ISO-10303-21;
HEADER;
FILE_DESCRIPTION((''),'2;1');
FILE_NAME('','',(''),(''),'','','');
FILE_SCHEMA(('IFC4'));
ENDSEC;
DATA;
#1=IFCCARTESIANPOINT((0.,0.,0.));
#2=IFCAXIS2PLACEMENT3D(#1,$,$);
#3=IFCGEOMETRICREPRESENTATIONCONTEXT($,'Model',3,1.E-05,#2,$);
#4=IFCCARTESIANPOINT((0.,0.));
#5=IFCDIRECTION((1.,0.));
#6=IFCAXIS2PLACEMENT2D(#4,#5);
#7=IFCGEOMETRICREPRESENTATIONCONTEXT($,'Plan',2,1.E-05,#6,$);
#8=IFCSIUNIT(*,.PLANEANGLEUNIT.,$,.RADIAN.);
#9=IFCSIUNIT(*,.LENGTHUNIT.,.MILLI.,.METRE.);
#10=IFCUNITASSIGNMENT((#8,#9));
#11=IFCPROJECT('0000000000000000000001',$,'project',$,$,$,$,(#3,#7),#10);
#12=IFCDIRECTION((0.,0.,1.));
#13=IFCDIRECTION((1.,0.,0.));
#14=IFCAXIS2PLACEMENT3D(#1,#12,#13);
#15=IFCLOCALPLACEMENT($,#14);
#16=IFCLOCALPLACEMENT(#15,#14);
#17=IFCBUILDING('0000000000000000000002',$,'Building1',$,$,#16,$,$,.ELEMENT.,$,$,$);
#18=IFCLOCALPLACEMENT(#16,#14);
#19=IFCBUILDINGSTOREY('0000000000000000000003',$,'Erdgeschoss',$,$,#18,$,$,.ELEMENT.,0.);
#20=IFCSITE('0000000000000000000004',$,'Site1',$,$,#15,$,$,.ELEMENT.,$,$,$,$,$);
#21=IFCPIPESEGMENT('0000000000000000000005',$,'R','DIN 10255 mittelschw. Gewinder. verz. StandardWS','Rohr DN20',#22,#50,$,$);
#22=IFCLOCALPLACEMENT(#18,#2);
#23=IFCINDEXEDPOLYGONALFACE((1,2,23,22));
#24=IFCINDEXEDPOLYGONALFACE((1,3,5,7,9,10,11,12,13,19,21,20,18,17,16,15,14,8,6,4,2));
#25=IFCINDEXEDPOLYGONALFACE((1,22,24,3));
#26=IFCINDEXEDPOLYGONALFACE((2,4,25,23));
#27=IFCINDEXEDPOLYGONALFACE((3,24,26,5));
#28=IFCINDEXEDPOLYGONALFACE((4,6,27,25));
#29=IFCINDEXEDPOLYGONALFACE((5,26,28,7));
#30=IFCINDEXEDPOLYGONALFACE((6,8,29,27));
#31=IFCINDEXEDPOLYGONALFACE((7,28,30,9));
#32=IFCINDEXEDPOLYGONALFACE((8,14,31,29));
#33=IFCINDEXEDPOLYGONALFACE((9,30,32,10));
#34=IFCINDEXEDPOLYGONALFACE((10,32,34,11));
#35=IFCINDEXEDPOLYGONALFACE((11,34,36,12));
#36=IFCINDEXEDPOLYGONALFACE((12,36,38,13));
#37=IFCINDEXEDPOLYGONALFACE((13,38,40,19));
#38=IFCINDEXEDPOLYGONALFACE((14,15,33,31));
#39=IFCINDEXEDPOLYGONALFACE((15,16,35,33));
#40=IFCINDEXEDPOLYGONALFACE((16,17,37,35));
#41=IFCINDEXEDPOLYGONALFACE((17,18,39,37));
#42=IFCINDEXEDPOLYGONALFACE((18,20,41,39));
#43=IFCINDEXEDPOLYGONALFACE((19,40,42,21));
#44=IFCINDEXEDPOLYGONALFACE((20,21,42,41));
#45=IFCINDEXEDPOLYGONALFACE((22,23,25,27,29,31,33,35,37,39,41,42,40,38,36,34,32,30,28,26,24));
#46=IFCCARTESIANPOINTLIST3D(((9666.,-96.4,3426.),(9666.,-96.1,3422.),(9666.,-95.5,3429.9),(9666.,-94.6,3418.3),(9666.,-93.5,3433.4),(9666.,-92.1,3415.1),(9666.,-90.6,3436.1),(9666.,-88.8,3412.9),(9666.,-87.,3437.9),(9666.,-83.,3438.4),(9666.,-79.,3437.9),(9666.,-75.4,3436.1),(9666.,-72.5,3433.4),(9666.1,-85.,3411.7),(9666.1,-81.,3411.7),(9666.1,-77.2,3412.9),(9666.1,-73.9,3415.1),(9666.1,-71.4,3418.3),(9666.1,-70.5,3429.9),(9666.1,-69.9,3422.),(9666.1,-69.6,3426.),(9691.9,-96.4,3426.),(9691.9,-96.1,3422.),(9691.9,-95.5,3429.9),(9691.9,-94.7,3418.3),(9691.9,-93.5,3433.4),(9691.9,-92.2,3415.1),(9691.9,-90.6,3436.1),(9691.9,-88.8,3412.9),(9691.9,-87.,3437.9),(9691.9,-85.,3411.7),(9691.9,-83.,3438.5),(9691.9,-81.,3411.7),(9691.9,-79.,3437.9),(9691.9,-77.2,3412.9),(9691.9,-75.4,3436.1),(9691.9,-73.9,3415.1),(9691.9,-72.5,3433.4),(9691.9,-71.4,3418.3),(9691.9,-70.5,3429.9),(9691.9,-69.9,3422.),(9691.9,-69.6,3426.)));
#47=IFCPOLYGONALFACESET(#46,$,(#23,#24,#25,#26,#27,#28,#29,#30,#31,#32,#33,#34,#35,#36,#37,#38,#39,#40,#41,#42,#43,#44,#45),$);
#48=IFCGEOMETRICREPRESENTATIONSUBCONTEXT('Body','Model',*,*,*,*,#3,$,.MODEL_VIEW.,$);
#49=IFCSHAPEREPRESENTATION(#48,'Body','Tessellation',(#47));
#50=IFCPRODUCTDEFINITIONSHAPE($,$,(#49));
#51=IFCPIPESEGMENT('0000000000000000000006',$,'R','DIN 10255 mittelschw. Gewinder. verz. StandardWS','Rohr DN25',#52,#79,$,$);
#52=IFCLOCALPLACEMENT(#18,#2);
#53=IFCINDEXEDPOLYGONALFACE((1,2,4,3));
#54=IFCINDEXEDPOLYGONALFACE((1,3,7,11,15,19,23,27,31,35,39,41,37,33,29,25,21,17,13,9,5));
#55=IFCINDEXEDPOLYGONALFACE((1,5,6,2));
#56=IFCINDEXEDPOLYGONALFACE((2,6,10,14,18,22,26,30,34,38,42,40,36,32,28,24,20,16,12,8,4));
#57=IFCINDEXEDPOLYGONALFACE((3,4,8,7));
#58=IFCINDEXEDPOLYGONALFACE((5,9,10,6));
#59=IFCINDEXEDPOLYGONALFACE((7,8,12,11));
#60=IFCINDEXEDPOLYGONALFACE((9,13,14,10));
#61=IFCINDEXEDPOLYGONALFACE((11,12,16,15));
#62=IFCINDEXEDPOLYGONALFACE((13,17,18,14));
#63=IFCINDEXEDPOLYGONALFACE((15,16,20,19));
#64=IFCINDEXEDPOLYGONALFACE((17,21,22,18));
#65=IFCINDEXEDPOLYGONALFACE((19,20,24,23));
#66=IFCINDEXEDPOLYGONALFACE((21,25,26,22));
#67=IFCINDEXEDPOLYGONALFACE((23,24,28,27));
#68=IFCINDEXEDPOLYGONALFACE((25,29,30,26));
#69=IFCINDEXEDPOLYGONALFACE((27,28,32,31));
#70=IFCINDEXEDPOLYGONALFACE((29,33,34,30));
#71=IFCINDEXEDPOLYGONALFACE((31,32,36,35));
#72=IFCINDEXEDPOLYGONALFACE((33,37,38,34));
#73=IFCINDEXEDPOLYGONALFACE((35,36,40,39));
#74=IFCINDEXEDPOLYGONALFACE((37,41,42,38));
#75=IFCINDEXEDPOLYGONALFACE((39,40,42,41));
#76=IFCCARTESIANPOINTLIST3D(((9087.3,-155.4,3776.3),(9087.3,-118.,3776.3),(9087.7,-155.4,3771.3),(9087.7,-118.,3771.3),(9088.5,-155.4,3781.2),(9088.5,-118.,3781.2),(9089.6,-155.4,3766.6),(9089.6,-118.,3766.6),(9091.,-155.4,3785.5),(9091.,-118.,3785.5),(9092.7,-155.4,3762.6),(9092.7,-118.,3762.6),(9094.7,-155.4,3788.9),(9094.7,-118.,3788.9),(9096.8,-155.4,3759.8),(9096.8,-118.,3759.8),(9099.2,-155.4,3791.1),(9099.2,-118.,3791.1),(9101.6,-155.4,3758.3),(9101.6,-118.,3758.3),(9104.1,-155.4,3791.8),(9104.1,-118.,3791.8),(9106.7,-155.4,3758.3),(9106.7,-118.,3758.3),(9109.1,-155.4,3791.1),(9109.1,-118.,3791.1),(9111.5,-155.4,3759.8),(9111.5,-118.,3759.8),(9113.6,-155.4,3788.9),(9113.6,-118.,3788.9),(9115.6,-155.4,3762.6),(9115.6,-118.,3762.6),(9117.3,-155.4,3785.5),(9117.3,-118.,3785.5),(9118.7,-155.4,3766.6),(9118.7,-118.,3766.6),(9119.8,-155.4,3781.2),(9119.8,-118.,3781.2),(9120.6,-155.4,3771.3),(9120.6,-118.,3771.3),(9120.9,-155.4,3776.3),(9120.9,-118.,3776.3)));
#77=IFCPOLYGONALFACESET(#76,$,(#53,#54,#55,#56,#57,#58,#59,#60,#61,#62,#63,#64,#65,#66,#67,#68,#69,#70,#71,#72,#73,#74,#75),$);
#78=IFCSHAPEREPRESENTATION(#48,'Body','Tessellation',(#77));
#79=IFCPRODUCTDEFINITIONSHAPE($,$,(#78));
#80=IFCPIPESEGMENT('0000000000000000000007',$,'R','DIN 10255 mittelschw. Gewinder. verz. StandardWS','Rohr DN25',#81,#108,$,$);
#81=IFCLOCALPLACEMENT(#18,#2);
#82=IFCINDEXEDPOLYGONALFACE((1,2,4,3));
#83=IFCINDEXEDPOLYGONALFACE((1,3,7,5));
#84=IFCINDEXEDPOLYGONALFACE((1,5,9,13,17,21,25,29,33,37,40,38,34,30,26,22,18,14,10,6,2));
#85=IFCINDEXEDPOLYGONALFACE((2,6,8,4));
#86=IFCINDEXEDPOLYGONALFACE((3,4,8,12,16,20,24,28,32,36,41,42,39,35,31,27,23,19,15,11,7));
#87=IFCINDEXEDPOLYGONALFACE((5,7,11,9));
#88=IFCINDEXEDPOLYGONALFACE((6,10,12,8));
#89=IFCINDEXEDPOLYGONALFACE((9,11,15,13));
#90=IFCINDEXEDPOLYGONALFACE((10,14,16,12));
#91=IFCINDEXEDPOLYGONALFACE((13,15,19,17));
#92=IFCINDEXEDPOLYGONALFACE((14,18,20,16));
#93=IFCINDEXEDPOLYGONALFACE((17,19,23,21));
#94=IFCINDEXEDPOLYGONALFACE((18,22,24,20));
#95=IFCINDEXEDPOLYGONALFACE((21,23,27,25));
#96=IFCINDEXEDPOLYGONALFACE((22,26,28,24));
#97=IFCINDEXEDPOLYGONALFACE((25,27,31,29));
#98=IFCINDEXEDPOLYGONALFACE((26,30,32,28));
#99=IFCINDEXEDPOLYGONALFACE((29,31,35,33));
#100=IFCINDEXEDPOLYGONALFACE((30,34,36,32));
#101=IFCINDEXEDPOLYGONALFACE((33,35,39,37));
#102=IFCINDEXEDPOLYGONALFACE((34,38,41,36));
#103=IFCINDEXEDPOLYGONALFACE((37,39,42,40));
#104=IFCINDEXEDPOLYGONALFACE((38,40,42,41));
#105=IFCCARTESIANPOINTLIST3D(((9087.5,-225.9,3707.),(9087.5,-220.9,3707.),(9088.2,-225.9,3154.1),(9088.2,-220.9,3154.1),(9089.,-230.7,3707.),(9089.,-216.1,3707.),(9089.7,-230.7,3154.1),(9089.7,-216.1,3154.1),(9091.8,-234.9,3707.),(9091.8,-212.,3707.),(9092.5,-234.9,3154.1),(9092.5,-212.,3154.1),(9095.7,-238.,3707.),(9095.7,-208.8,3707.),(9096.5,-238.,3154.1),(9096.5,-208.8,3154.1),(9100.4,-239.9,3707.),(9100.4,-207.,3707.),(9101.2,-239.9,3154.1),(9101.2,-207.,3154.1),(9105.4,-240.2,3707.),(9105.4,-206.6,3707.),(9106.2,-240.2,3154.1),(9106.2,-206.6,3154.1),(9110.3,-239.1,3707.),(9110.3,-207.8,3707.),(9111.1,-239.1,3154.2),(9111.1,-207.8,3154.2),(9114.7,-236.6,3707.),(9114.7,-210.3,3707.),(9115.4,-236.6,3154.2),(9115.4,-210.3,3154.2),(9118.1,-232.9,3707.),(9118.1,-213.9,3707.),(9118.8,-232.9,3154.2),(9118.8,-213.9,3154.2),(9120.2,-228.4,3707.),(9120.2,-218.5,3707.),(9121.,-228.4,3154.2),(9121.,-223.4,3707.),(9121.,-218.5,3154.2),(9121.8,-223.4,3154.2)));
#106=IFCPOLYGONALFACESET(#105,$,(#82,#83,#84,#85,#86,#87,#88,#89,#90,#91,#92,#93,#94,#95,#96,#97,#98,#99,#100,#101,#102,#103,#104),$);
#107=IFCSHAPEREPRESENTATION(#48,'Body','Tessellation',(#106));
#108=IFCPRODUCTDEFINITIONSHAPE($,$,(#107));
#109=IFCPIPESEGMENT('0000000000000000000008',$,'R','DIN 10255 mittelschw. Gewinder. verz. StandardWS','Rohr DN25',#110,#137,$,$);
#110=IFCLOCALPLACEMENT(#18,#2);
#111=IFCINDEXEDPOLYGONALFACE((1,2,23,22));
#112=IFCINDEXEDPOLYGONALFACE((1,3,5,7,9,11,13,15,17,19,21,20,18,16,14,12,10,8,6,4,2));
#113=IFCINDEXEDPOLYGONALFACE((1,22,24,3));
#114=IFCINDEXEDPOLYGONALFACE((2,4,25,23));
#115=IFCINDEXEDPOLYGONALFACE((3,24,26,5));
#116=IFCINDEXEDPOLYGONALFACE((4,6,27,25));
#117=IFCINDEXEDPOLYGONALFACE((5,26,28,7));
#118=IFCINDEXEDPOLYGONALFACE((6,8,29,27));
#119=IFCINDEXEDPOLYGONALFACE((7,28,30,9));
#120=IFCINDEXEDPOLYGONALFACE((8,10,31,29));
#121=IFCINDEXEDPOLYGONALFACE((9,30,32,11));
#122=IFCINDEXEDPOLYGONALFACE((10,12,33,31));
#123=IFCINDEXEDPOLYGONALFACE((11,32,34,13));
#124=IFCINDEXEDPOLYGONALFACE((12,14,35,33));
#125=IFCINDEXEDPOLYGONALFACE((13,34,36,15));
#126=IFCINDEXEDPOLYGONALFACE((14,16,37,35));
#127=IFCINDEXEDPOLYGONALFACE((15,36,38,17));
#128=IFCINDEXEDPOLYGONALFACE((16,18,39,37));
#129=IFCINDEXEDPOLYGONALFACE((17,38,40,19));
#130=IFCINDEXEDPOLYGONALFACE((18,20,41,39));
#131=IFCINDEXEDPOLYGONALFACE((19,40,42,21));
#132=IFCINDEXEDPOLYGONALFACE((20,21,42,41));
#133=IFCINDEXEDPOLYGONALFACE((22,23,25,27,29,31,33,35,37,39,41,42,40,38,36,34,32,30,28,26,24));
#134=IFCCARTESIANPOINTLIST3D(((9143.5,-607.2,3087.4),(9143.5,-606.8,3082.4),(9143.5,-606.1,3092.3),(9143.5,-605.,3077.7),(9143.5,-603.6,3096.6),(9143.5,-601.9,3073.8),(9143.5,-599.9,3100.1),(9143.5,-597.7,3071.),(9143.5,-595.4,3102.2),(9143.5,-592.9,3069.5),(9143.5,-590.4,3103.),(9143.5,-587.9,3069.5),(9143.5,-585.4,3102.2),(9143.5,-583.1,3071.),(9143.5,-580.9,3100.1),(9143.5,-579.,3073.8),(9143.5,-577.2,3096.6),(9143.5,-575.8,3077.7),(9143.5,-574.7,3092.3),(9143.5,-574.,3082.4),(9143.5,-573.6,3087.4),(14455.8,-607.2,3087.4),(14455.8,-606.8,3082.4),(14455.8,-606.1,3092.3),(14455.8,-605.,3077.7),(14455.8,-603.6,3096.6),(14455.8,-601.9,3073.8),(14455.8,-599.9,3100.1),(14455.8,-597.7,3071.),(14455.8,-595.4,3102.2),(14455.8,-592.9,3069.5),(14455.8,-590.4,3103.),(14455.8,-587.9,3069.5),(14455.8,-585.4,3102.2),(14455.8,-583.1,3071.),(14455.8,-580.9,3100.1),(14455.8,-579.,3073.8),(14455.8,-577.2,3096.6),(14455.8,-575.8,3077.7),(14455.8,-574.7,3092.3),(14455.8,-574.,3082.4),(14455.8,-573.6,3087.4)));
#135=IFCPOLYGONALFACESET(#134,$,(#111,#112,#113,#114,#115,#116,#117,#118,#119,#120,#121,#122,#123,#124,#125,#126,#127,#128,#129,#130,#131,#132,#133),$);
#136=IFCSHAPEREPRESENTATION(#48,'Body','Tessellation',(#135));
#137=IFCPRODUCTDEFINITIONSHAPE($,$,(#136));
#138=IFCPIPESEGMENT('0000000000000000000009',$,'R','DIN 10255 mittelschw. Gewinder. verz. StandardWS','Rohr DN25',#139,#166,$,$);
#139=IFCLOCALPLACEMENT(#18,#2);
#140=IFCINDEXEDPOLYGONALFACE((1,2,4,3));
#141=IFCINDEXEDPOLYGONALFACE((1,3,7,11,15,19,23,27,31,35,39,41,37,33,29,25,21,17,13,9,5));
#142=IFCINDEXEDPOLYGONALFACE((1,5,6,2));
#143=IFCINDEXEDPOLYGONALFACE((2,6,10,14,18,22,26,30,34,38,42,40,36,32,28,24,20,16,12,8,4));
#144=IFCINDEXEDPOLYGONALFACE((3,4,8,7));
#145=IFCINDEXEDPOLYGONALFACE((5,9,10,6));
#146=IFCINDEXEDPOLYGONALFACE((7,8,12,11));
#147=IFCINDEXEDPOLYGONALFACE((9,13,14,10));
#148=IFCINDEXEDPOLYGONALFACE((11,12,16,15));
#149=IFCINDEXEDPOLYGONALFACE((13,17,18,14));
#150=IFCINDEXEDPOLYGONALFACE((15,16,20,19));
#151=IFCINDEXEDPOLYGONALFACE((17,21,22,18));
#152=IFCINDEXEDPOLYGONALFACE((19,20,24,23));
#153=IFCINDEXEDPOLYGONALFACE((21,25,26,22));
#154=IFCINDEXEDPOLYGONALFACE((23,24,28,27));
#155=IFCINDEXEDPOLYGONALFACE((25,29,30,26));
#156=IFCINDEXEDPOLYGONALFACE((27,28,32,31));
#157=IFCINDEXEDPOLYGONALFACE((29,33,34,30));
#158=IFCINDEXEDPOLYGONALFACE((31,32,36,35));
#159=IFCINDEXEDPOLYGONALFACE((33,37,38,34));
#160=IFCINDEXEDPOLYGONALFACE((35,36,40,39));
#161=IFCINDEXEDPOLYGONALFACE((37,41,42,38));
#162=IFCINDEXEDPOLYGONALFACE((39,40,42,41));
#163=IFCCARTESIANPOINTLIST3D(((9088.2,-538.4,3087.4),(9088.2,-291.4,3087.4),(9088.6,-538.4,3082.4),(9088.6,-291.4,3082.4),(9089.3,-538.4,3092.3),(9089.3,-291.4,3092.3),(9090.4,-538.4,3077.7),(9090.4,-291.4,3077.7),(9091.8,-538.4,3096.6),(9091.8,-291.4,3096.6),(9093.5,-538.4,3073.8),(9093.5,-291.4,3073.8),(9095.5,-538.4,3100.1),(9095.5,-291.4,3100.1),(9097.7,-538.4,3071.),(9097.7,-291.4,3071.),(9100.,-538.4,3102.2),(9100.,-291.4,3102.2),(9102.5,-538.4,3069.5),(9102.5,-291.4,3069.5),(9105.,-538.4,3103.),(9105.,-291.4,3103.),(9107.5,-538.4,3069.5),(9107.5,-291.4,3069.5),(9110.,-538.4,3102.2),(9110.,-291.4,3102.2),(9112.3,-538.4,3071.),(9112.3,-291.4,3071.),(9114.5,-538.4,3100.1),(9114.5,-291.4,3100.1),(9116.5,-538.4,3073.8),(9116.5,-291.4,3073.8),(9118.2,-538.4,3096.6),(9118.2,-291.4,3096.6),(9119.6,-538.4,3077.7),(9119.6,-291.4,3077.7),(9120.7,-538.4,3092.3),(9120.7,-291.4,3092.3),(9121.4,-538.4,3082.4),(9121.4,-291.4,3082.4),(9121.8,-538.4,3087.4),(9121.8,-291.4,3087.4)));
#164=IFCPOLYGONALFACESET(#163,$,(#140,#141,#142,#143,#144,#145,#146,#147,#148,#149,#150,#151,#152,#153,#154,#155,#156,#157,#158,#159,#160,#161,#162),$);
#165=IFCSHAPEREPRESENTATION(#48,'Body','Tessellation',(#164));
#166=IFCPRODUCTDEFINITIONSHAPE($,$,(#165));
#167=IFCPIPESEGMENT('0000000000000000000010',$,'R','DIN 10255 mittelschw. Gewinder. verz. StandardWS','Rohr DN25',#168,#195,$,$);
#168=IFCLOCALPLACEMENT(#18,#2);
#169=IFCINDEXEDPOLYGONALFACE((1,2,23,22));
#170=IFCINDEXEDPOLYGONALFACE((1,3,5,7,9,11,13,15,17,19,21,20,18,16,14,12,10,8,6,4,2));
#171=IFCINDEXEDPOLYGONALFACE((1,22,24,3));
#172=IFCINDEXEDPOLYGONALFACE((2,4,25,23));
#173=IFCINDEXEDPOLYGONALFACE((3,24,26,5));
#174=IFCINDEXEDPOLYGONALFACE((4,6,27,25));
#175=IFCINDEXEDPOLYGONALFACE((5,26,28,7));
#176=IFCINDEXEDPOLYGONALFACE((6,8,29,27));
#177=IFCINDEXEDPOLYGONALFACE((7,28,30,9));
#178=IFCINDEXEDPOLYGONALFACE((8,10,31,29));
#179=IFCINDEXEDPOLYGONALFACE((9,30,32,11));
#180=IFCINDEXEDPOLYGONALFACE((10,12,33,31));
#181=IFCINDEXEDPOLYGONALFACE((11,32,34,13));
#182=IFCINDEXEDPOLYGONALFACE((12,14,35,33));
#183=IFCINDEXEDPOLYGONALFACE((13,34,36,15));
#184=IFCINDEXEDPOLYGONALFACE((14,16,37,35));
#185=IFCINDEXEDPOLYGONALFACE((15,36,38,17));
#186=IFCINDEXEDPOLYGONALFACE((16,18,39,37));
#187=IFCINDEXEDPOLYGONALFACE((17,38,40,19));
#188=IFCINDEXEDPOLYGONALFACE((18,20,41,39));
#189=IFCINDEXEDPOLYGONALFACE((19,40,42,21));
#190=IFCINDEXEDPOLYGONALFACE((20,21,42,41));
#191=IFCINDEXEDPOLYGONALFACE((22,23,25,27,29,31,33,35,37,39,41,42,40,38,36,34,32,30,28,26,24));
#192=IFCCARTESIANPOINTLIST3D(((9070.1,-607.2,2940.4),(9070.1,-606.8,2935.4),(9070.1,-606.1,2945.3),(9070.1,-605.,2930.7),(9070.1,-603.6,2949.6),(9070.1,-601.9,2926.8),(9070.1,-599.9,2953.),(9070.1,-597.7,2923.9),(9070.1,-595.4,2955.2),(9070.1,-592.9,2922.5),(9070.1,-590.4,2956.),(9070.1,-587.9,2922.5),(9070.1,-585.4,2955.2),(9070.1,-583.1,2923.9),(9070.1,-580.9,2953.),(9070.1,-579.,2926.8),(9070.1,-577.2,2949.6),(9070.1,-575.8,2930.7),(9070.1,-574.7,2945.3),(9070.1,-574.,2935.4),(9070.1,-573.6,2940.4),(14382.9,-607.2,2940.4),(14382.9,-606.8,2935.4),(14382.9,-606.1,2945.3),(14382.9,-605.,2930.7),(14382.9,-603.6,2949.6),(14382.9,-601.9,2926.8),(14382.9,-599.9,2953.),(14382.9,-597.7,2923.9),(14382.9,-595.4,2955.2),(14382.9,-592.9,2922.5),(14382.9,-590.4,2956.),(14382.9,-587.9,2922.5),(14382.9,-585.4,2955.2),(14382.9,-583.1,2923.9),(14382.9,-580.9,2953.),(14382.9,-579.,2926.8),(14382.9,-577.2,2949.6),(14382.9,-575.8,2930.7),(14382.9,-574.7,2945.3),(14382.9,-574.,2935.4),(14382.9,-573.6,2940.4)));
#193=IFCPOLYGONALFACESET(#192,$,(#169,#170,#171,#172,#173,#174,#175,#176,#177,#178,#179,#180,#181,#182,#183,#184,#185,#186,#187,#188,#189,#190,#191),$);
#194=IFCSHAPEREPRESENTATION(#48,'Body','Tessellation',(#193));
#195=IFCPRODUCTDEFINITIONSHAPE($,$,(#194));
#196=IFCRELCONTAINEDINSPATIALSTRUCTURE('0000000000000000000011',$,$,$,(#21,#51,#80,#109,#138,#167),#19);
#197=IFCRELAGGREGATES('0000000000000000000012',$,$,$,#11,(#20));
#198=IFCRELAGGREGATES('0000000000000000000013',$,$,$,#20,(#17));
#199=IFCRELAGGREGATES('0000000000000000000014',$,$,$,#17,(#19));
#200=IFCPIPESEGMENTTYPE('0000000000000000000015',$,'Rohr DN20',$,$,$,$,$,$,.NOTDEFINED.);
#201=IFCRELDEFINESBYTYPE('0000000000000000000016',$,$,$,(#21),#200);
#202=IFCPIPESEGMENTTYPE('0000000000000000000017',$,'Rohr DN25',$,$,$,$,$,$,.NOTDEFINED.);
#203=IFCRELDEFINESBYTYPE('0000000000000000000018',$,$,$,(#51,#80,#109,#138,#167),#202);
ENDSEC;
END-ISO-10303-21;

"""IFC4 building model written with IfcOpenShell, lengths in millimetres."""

from ifc_helpers import new_model, si_unit, frame, origin, origin_with_axes, origin_2d_with_axis, place, context, subcontext, project, spatial, circle, extrude, type_object, element, save


model = new_model("IFC4")

# Units and contexts
model_context = context("Model", 3, precision=1e-05, world=origin())
plan_context = context("Plan", 2, precision=1e-05, world=origin_2d_with_axis())
body_context = subcontext(model_context, "Body", "Model", "MODEL_VIEW")
ifc_project = project(units=[si_unit("PLANEANGLEUNIT", "RADIAN"), si_unit("LENGTHUNIT", "METRE", prefix="MILLI")], contexts=[model_context, plan_context])

# Site, building, storey
site_placement = place(None, origin_with_axes())
site = spatial("IfcSite", under=ifc_project, at=site_placement, Name="Site1", CompositionType="ELEMENT")
building_placement = place(site_placement, origin_with_axes())
building = spatial("IfcBuilding", under=site, at=building_placement, Name="Building1", CompositionType="ELEMENT")
storey_placement = place(building_placement, origin_with_axes())
storey = spatial("IfcBuildingStorey", under=building, at=storey_placement, Name="Erdgeschoss", CompositionType="ELEMENT", Elevation=0.0)

# Pipe segments
pipe_segment_type_1 = type_object("IfcPipeSegmentType", Name="Rohr DN20", PredefinedType="NOTDEFINED")
pipe_segment_1_placement = place(storey_placement, frame((9679.0, -83.2, 3425.0), z_axis=(0.0, 0.0, 1.0), x_axis=(1.0, 0.0, 0.0)))
element("IfcPipeSegment", 1, at=pipe_segment_1_placement, inside=storey, type_object=pipe_segment_type_1, Name="R", Description="DIN 10255 mittelschw. Gewinder. verz. StandardWS", ObjectType="Rohr DN20", context=body_context, shape_type="SolidModel", body=[
    extrude(circle(Radius=13.4, at=origin_2d_with_axis()), frame((12.9, 0.1, 0.0), z_axis=(-1.0, 0.000127, -0.000091), x_axis=(0.0, 0.0, 1.0)), (0.0, 0.0, 1.0), 25.8),
])
pipe_segment_type_2 = type_object("IfcPipeSegmentType", Name="Rohr DN25", PredefinedType="NOTDEFINED")
pipe_segment_2_placement = place(storey_placement, frame((9104.3, -136.7, 3775.0), z_axis=(0.0, 0.0, 1.0), x_axis=(1.0, 0.0, 0.0)))
element("IfcPipeSegment", 2, at=pipe_segment_2_placement, inside=storey, type_object=pipe_segment_type_2, Name="R", Description="DIN 10255 mittelschw. Gewinder. verz. StandardWS", ObjectType="Rohr DN25", context=body_context, shape_type="SolidModel", body=[
    extrude(circle(Radius=16.9, at=origin_2d_with_axis()), frame((-0.1, 18.7, 0.0), z_axis=(0.0, -1.0, 0.0), x_axis=(0.0, 0.0, 1.0)), (0.0, 0.0, 1.0), 37.4),
])
pipe_segment_3_placement = place(storey_placement, frame((9104.5, -223.3, 3430.6), z_axis=(0.0, 0.0, 1.0), x_axis=(1.0, 0.0, 0.0)))
element("IfcPipeSegment", 3, at=pipe_segment_3_placement, inside=storey, type_object=pipe_segment_type_2, Name="R", Description="DIN 10255 mittelschw. Gewinder. verz. StandardWS", ObjectType="Rohr DN25", context=body_context, shape_type="SolidModel", body=[
    extrude(circle(Radius=16.9, at=origin_2d_with_axis()), frame((-0.4, -0.2, 276.4), z_axis=(0.001364, 0.0, -0.999999), x_axis=(1.0, 0.0, 0.0)), (0.0, 0.0, 1.0), 552.9),
])
pipe_segment_4_placement = place(storey_placement, frame((11799.6, -590.3, 3086.1), z_axis=(0.0, 0.0, 1.0), x_axis=(1.0, 0.0, 0.0)))
element("IfcPipeSegment", 4, at=pipe_segment_4_placement, inside=storey, type_object=pipe_segment_type_2, Name="R", Description="DIN 10255 mittelschw. Gewinder. verz. StandardWS", ObjectType="Rohr DN25", context=body_context, shape_type="SolidModel", body=[
    extrude(circle(Radius=16.9, at=origin_2d_with_axis()), frame((-2656.1, -0.2, 0.0), z_axis=(1.0, 0.0, 0.0), x_axis=(0.0, 0.0, 1.0)), (0.0, 0.0, 1.0), 5312.3),
])
pipe_segment_5_placement = place(storey_placement, frame((9104.8, -414.9, 3086.1), z_axis=(0.0, 0.0, 1.0), x_axis=(1.0, 0.0, 0.0)))
element("IfcPipeSegment", 5, at=pipe_segment_5_placement, inside=storey, type_object=pipe_segment_type_2, Name="R", Description="DIN 10255 mittelschw. Gewinder. verz. StandardWS", ObjectType="Rohr DN25", context=body_context, shape_type="SolidModel", body=[
    extrude(circle(Radius=16.9, at=origin_2d_with_axis()), frame((0.1, -123.5, 0.0), z_axis=(0.0, 1.0, 0.0), x_axis=(0.0, 0.0, 1.0)), (0.0, 0.0, 1.0), 247.0),
])
pipe_segment_6_placement = place(storey_placement, frame((11726.5, -590.3, 2939.1), z_axis=(0.0, 0.0, 1.0), x_axis=(1.0, 0.0, 0.0)))
element("IfcPipeSegment", 6, at=pipe_segment_6_placement, inside=storey, type_object=pipe_segment_type_2, Name="R", Description="DIN 10255 mittelschw. Gewinder. verz. StandardWS", ObjectType="Rohr DN25", context=body_context, shape_type="SolidModel", body=[
    extrude(circle(Radius=16.9, at=origin_2d_with_axis()), frame((-2656.4, -0.2, 0.0), z_axis=(1.0, 0.0, 0.0), x_axis=(0.0, 0.0, 1.0)), (0.0, 0.0, 1.0), 5312.8),
])

save(model, "model.ifc")
